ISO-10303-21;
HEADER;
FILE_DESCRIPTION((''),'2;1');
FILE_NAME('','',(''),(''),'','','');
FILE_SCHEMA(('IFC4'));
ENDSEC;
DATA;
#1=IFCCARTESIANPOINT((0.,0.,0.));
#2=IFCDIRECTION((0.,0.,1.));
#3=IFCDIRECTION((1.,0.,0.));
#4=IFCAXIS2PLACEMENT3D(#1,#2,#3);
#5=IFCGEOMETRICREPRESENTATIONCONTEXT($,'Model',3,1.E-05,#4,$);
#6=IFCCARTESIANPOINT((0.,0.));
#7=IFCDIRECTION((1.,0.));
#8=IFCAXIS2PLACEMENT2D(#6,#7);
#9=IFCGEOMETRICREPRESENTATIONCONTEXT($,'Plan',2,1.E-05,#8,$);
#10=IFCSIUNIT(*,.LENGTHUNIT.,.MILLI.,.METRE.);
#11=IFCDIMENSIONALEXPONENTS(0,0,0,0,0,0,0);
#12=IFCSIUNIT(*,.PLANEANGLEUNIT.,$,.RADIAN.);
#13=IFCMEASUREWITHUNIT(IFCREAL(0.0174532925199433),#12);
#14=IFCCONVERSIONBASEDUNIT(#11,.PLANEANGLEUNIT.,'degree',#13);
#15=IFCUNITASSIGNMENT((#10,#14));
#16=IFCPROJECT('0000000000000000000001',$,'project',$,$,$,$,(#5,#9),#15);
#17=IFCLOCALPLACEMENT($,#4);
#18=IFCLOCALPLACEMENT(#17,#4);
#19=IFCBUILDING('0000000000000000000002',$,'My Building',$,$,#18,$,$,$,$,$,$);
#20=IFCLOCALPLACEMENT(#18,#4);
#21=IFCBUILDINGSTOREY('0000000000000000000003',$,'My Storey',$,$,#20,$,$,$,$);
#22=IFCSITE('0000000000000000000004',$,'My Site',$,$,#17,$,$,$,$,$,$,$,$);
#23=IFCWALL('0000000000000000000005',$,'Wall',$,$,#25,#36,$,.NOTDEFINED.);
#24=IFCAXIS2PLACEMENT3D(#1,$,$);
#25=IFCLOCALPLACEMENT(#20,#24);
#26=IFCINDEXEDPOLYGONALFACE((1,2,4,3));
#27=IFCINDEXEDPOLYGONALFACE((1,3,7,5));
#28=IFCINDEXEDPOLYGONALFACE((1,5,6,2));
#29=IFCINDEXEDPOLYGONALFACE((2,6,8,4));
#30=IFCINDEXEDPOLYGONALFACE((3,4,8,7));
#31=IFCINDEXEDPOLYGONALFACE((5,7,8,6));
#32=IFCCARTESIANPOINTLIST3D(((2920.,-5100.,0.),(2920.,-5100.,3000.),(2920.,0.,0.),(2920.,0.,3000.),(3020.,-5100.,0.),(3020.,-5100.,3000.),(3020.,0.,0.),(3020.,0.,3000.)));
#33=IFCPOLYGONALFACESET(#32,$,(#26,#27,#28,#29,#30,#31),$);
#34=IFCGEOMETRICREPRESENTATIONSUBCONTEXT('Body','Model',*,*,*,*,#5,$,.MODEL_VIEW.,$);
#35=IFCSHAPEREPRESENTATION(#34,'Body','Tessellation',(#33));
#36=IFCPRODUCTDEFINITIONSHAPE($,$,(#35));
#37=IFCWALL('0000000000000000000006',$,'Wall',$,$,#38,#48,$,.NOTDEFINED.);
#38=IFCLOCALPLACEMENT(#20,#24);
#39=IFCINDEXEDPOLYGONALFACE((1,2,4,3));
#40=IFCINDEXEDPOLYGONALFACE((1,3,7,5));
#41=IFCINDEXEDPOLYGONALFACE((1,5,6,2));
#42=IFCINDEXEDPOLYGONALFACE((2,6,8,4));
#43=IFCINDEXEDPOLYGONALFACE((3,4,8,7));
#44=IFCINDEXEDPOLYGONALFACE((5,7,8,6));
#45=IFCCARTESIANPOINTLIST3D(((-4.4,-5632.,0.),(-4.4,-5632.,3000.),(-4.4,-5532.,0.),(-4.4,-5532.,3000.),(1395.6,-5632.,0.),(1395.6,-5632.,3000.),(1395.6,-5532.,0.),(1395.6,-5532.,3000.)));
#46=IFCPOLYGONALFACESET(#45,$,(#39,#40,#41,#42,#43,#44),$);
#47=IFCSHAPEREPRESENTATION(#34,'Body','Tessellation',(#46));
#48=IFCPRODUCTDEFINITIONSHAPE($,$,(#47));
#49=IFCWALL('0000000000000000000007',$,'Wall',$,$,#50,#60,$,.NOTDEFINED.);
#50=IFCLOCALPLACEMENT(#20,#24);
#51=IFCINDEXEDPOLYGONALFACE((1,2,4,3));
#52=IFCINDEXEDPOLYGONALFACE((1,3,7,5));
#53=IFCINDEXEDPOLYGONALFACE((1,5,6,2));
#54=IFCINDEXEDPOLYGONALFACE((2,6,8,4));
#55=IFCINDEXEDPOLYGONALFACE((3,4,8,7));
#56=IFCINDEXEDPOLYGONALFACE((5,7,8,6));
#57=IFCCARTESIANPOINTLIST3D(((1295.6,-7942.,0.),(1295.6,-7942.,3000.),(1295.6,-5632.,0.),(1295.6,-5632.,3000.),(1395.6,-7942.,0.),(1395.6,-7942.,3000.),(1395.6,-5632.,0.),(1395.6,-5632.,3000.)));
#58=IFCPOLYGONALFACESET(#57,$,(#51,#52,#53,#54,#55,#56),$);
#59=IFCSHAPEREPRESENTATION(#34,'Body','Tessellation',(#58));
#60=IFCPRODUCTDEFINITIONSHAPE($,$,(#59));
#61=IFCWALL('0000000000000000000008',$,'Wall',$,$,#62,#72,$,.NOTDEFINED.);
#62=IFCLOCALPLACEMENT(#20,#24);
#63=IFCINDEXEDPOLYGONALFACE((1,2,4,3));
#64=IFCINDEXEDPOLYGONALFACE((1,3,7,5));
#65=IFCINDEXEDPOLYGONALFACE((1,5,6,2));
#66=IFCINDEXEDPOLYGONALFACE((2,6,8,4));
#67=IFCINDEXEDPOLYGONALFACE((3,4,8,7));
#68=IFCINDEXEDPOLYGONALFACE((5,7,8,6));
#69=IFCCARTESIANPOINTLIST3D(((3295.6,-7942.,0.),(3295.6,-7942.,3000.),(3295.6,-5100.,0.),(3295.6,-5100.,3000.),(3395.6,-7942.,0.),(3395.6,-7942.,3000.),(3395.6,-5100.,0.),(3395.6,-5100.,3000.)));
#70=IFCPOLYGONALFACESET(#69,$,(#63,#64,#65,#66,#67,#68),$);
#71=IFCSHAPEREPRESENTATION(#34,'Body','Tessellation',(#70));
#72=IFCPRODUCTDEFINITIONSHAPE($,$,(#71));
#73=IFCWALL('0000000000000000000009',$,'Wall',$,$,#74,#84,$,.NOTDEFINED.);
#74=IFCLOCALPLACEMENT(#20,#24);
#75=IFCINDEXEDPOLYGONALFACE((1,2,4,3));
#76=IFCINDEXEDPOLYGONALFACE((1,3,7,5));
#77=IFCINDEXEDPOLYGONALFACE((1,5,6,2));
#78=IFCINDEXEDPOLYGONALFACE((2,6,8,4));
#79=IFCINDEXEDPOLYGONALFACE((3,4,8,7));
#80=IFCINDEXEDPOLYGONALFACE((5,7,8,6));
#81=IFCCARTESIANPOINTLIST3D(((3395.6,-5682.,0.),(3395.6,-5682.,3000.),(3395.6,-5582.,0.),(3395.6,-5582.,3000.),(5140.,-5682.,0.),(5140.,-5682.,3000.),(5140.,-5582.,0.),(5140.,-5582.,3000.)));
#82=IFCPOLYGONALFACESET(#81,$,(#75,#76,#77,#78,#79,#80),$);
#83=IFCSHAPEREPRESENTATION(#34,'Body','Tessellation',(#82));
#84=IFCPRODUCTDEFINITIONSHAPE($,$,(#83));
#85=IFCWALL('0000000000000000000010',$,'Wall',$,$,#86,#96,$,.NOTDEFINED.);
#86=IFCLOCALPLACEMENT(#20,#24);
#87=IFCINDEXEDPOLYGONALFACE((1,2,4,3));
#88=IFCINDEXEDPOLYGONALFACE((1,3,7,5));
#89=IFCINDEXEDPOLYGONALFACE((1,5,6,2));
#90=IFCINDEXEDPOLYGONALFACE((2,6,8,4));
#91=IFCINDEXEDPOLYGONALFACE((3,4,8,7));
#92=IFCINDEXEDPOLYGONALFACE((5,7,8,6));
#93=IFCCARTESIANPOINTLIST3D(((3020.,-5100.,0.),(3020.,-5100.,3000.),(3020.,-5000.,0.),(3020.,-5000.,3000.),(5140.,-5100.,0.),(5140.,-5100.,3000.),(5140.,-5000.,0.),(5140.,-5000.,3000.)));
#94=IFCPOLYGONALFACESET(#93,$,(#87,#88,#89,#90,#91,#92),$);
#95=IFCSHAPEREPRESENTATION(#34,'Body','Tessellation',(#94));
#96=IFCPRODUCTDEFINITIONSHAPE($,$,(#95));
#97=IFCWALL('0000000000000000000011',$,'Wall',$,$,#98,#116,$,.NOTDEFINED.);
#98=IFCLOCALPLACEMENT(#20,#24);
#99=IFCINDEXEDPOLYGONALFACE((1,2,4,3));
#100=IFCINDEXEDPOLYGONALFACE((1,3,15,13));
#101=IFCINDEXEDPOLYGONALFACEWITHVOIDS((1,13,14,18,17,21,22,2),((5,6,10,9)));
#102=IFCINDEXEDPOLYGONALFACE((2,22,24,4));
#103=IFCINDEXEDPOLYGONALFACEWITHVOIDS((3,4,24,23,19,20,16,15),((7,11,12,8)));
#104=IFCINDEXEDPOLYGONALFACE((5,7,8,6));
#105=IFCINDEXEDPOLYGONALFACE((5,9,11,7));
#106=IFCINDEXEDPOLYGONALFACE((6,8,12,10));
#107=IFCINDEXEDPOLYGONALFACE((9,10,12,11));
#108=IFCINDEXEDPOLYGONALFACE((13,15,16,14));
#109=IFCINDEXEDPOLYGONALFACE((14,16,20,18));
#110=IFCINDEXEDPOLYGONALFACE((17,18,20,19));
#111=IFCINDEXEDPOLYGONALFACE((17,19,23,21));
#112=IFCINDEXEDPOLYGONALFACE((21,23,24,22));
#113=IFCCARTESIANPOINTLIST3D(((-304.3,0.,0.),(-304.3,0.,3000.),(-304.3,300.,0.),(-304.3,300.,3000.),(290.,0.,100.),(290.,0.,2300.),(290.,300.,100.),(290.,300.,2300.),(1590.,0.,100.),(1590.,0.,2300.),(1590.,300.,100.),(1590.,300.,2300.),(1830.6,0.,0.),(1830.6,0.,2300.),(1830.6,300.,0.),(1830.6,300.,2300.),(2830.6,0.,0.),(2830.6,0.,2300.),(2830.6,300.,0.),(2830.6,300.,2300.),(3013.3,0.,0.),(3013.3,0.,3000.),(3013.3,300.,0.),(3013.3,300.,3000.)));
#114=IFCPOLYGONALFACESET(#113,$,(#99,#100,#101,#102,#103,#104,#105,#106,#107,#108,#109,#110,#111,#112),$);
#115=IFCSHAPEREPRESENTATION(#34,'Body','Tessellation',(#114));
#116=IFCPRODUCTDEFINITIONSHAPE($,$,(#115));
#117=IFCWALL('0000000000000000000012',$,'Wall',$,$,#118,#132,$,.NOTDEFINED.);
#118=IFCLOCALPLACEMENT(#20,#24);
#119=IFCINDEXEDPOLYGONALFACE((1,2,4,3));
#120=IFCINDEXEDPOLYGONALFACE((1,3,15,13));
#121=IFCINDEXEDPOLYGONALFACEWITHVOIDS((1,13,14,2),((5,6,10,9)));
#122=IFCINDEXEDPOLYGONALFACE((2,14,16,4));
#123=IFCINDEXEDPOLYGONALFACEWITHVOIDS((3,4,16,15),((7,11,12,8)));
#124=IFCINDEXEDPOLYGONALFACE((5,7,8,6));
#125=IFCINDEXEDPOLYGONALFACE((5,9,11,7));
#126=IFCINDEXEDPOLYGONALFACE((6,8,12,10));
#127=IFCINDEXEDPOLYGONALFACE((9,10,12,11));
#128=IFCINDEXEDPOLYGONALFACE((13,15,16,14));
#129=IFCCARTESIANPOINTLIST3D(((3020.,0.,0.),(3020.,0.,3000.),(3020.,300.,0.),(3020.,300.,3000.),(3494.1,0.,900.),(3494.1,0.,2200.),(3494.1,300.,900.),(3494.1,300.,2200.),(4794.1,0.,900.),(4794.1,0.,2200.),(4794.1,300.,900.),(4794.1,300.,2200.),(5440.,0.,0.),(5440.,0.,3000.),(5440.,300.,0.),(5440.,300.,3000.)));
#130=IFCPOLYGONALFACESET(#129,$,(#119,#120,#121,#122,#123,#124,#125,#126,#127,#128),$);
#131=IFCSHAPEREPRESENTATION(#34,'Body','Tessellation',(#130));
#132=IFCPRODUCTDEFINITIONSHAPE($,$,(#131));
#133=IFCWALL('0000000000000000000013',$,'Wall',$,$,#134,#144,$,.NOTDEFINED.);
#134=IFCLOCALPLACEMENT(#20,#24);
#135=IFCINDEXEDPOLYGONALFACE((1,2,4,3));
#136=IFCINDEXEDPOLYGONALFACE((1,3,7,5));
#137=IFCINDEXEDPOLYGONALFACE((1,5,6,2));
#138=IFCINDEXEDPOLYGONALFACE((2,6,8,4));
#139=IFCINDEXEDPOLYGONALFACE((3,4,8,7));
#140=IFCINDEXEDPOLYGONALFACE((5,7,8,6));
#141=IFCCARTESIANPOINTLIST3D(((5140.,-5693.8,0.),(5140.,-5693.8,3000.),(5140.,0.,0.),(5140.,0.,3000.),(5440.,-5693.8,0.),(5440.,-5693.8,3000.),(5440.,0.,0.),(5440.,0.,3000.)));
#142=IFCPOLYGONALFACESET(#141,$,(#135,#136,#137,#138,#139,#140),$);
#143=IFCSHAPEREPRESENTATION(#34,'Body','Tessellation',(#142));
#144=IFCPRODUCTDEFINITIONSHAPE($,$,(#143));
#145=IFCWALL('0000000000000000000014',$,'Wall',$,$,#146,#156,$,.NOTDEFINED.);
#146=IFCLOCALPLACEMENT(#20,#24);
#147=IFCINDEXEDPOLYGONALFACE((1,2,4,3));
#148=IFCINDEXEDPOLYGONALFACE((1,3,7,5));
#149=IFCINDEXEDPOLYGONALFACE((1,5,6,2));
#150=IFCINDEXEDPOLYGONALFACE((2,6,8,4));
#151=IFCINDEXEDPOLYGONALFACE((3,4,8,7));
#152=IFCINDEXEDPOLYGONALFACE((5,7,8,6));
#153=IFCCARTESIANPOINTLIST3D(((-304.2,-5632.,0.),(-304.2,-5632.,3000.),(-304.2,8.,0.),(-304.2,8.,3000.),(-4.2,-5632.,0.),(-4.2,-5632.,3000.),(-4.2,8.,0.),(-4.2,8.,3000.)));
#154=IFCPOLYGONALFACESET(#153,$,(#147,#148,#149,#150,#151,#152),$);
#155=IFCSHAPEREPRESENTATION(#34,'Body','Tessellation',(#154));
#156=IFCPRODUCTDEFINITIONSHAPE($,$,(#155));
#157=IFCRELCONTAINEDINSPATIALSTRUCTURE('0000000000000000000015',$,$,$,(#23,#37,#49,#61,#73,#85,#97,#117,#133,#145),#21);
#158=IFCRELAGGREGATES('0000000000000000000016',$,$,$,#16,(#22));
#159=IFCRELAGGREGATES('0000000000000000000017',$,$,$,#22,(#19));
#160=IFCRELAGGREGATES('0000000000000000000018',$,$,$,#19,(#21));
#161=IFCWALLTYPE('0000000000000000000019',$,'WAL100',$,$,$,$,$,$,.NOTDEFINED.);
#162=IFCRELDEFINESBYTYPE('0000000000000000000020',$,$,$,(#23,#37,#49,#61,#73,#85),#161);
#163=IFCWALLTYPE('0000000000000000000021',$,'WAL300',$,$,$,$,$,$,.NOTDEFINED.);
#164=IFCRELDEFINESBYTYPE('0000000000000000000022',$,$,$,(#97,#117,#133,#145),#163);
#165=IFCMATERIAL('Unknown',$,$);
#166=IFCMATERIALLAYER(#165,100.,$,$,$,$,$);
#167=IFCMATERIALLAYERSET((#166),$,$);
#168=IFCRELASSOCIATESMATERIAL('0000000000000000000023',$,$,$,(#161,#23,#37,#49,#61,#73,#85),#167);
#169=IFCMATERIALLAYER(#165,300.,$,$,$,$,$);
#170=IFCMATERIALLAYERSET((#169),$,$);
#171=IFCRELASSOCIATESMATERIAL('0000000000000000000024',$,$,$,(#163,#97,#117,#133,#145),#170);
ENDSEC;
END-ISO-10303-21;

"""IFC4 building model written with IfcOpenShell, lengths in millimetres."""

from ifc_helpers import new_model, entity, si_unit, converted_unit, frame, origin_with_axes, origin_2d_with_axis, place, context, subcontext, project, spatial, line, indexed_curve, outline, extrude, source, transform, mapped, material, layer, layer_set, layer_usage, type_object, element, save


model = new_model("IFC4")

# Units and contexts
model_context = context("Model", 3, precision=1e-05, world=origin_with_axes())
plan_context = context("Plan", 2, precision=1e-05, world=origin_2d_with_axis())
body_context = subcontext(model_context, "Body", "Model", "MODEL_VIEW")
ifc_project = project(units=[si_unit("LENGTHUNIT", "METRE", prefix="MILLI"), converted_unit("PLANEANGLEUNIT", "degree", entity("IfcReal", 0.0174532925199433), si_unit("PLANEANGLEUNIT", "RADIAN"), dimensions=[0, 0, 0, 0, 0, 0, 0])], contexts=[model_context, plan_context])

# Site, building, storey
site_placement = place(None, origin_with_axes())
site = spatial("IfcSite", under=ifc_project, at=site_placement, Name="My Site")
building_placement = place(site_placement, origin_with_axes())
building = spatial("IfcBuilding", under=site, at=building_placement, Name="My Building")
storey_placement = place(building_placement, origin_with_axes())
storey = spatial("IfcBuildingStorey", under=building, at=storey_placement, Name="My Storey")

# Walls
ifc_material = material(Name="Unknown")
ifc_layer_1 = layer(ifc_material, 100.0)
ifc_layer_set_1 = layer_set([ifc_layer_1])
ifc_layer_usage_1 = layer_usage(ifc_layer_set_1, "AXIS2", "POSITIVE", 0.0)
wall_type_1 = type_object("IfcWallType", Name="WAL100", PredefinedType="NOTDEFINED", material=ifc_layer_set_1)
wall_1_placement = place(storey_placement, frame((2920.0, 0.0, 0.0), z_axis=(0.0, 0.0, 1.0), x_axis=(0.0, -1.0, 0.0)))
element("IfcWall", 1, at=wall_1_placement, inside=storey, type_object=wall_type_1, material=ifc_layer_usage_1, Name="Wall", PredefinedType="NOTDEFINED", context=body_context, shape_type="SweptSolid", body=[
    extrude(outline(indexed_curve([(0.0, 0.0), (0.0, 100.0), (5100.0, 100.0), (5100.0, 0.0), (0.0, 0.0)], self_intersect=False)), origin_with_axes(), (0.0, 0.0, 1.0), 3000.0),
])
ifc_layer_usage_2 = layer_usage(ifc_layer_set_1, "AXIS2", "POSITIVE", 0.0)
wall_2_placement = place(storey_placement, frame((1395.6, -5532.0, 0.0), z_axis=(0.0, 0.0, 1.0), x_axis=(-1.0, 0.000001, 0.0)))
element("IfcWall", 2, at=wall_2_placement, inside=storey, type_object=wall_type_1, material=ifc_layer_usage_2, Name="Wall", PredefinedType="NOTDEFINED", context=body_context, shape_type="SweptSolid", body=[
    extrude(outline(indexed_curve([(0.0, 0.0), (0.0, 100.0), (1400.0, 100.0), (1400.0, 0.0), (0.0, 0.0)], self_intersect=False)), origin_with_axes(), (0.0, 0.0, 1.0), 3000.0),
])
ifc_layer_usage_3 = layer_usage(ifc_layer_set_1, "AXIS2", "POSITIVE", 0.0)
wall_3_placement = place(storey_placement, frame((1295.6, -5632.0, 0.0), z_axis=(0.0, 0.0, 1.0), x_axis=(-0.000001, -1.0, 0.0)))
element("IfcWall", 3, at=wall_3_placement, inside=storey, type_object=wall_type_1, material=ifc_layer_usage_3, Name="Wall", PredefinedType="NOTDEFINED", context=body_context, shape_type="SweptSolid", body=[
    extrude(outline(indexed_curve([(0.0, 0.0), (0.0, 100.0), (2310.0, 100.0), (2310.0, 0.0), (0.0, 0.0)], self_intersect=False)), origin_with_axes(), (0.0, 0.0, 1.0), 3000.0),
])
ifc_layer_usage_4 = layer_usage(ifc_layer_set_1, "AXIS2", "POSITIVE", 0.0)
wall_4_placement = place(storey_placement, frame((3295.6, -5100.0, 0.0), z_axis=(0.0, 0.0, 1.0), x_axis=(-0.000001, -1.0, 0.0)))
element("IfcWall", 4, at=wall_4_placement, inside=storey, type_object=wall_type_1, material=ifc_layer_usage_4, Name="Wall", PredefinedType="NOTDEFINED", context=body_context, shape_type="SweptSolid", body=[
    extrude(outline(indexed_curve([(0.0, 0.0), (0.0, 100.0), (2842.0, 100.0), (2842.0, 0.0), (0.0, 0.0)], self_intersect=False)), origin_with_axes(), (0.0, 0.0, 1.0), 3000.0),
])
ifc_layer_usage_5 = layer_usage(ifc_layer_set_1, "AXIS2", "POSITIVE", 0.0)
wall_5_placement = place(storey_placement, frame((3395.6, -5682.0, 0.0), z_axis=(0.0, 0.0, 1.0), x_axis=(1.0, -0.000001, 0.0)))
element("IfcWall", 5, at=wall_5_placement, inside=storey, type_object=wall_type_1, material=ifc_layer_usage_5, Name="Wall", PredefinedType="NOTDEFINED", context=body_context, shape_type="SweptSolid", body=[
    extrude(outline(indexed_curve([(0.0, 0.0), (0.0, 100.0), (1744.4, 100.0), (1744.4, 0.0), (0.0, 0.0)], self_intersect=False)), origin_with_axes(), (0.0, 0.0, 1.0), 3000.0),
])
ifc_layer_usage_6 = layer_usage(ifc_layer_set_1, "AXIS2", "POSITIVE", 0.0)
wall_6_placement = place(storey_placement, frame((3020.0, -5100.0, 0.0), z_axis=(0.0, 0.0, 1.0), x_axis=(1.0, 0.0, 0.0)))
element("IfcWall", 6, at=wall_6_placement, inside=storey, type_object=wall_type_1, material=ifc_layer_usage_6, Name="Wall", PredefinedType="NOTDEFINED", context=body_context, shape_type="SweptSolid", body=[
    extrude(outline(indexed_curve([(0.0, 0.0), (0.0, 100.0), (2120.0, 100.0), (2120.0, 0.0), (0.0, 0.0)], self_intersect=False)), origin_with_axes(), (0.0, 0.0, 1.0), 3000.0),
])

# Wall, openings
ifc_layer_2 = layer(ifc_material, 300.0)
ifc_layer_set_2 = layer_set([ifc_layer_2])
ifc_layer_usage_7 = layer_usage(ifc_layer_set_2, "AXIS2", "POSITIVE", 0.0)
wall_type_2 = type_object("IfcWallType", Name="WAL300", PredefinedType="NOTDEFINED", material=ifc_layer_set_2)
wall_7_placement = place(storey_placement, frame((-304.3, 0.0, 0.0), z_axis=(0.0, 0.0, 1.0), x_axis=(1.0, 0.0, 0.0)))
wall_7 = element("IfcWall", 7, at=wall_7_placement, inside=storey, type_object=wall_type_2, material=ifc_layer_usage_7, Name="Wall", PredefinedType="NOTDEFINED", context=body_context, shape_type="SweptSolid", body=[
    extrude(outline(indexed_curve([(0.0, 0.0), (0.0, 300.0), (3317.5, 300.0), (3317.5, 0.0), (0.0, 0.0)], self_intersect=False)), origin_with_axes(), (0.0, 0.0, 1.0), 3000.0),
])
shared_shape_1 = source(origin_with_axes(), body_context, "Body", "SweptSolid", [
    extrude(outline(indexed_curve([(0.0, 0.0, 0.0), (1300.0, 0.0, 0.0), (1300.0, 0.0, 2200.0), (0.0, 0.0, 2200.0)], segments=[line(1, 2), line(2, 3), line(3, 4), line(4, 1)])), frame((0.0, -100.0, 0.0), z_axis=(0.0, 0.0, 1.0), x_axis=(1.0, 0.0, 0.0)), (0.0, 1.0, 0.0), 500.0),
])
opening_1_placement = place(wall_7_placement, frame((594.3, 50.0, 100.0), z_axis=(0.0, 0.0, 1.0), x_axis=(1.0, 0.0, 0.0)))
element("IfcOpeningElement", 8, at=opening_1_placement, cuts=wall_7, PredefinedType="OPENING", context=body_context, shape_type="MappedRepresentation", body=[
    mapped(shared_shape_1, transform((0.0, 0.0, 0.0), x_axis=(1.0, 0.0, 0.0), y_axis=(0.0, 1.0, 0.0), z_axis=(0.0, 0.0, 1.0), scale=1.0)),
])
shared_shape_2 = source(origin_with_axes(), body_context, "Body", "SweptSolid", [
    extrude(outline(indexed_curve([(0.0, 0.0, 0.0), (1000.0, 0.0, 0.0), (1000.0, 0.0, 2300.0), (0.0, 0.0, 2300.0)], segments=[line(1, 2), line(2, 3), line(3, 4), line(4, 1)])), frame((0.0, -100.0, 0.0), z_axis=(0.0, 0.0, 1.0), x_axis=(1.0, 0.0, 0.0)), (0.0, 1.0, 0.0), 500.0),
])
opening_2_placement = place(wall_7_placement, frame((2134.9, 0.0, 0.0), z_axis=(0.0, 0.0, 1.0), x_axis=(1.0, 0.0, 0.0)))
element("IfcOpeningElement", 9, at=opening_2_placement, cuts=wall_7, PredefinedType="OPENING", context=body_context, shape_type="MappedRepresentation", body=[
    mapped(shared_shape_2, transform((0.0, 0.0, 0.0), x_axis=(1.0, 0.0, 0.0), y_axis=(0.0, 1.0, 0.0), z_axis=(0.0, 0.0, 1.0), scale=1.0)),
])

# Wall, opening
ifc_layer_usage_8 = layer_usage(ifc_layer_set_2, "AXIS2", "POSITIVE", 0.0)
wall_8_placement = place(storey_placement, frame((3020.0, 0.0, 0.0), z_axis=(0.0, 0.0, 1.0), x_axis=(1.0, 0.0, 0.0)))
wall_8 = element("IfcWall", 10, at=wall_8_placement, inside=storey, type_object=wall_type_2, material=ifc_layer_usage_8, Name="Wall", PredefinedType="NOTDEFINED", context=body_context, shape_type="SweptSolid", body=[
    extrude(outline(indexed_curve([(0.0, 0.0), (0.0, 300.0), (2420.0, 300.0), (2420.0, 0.0), (0.0, 0.0)], self_intersect=False)), origin_with_axes(), (0.0, 0.0, 1.0), 3000.0),
])
shared_shape_3 = source(origin_with_axes(), body_context, "Body", "SweptSolid", [
    extrude(outline(indexed_curve([(0.0, 0.0, 0.0), (1300.0, 0.0, 0.0), (1300.0, 0.0, 1300.0), (0.0, 0.0, 1300.0)], segments=[line(1, 2), line(2, 3), line(3, 4), line(4, 1)])), frame((0.0, -100.0, 0.0), z_axis=(0.0, 0.0, 1.0), x_axis=(1.0, 0.0, 0.0)), (0.0, 1.0, 0.0), 500.0),
])
opening_3_placement = place(wall_8_placement, frame((474.1, 0.0, 900.0), z_axis=(0.0, 0.0, 1.0), x_axis=(1.0, 0.0, 0.0)))
element("IfcOpeningElement", 11, at=opening_3_placement, cuts=wall_8, PredefinedType="OPENING", context=body_context, shape_type="MappedRepresentation", body=[
    mapped(shared_shape_3, transform((0.0, 0.0, 0.0), x_axis=(1.0, 0.0, 0.0), y_axis=(0.0, 1.0, 0.0), z_axis=(0.0, 0.0, 1.0), scale=1.0)),
])

# Walls
ifc_layer_usage_9 = layer_usage(ifc_layer_set_2, "AXIS2", "POSITIVE", 0.0)
wall_9_placement = place(storey_placement, frame((5140.0, 0.0, 0.0), z_axis=(0.0, 0.0, 1.0), x_axis=(0.0, -1.0, 0.0)))
element("IfcWall", 12, at=wall_9_placement, inside=storey, type_object=wall_type_2, material=ifc_layer_usage_9, Name="Wall", PredefinedType="NOTDEFINED", context=body_context, shape_type="SweptSolid", body=[
    extrude(outline(indexed_curve([(0.0, 0.0), (0.0, 300.0), (5693.8, 300.0), (5693.8, 0.0), (0.0, 0.0)], self_intersect=False)), origin_with_axes(), (0.0, 0.0, 1.0), 3000.0),
])
ifc_layer_usage_10 = layer_usage(ifc_layer_set_2, "AXIS2", "POSITIVE", 0.0)
wall_10_placement = place(storey_placement, frame((-4.2, -5632.0, 0.0), z_axis=(0.0, 0.0, 1.0), x_axis=(0.0, 1.0, 0.0)))
element("IfcWall", 13, at=wall_10_placement, inside=storey, type_object=wall_type_2, material=ifc_layer_usage_10, Name="Wall", PredefinedType="NOTDEFINED", context=body_context, shape_type="SweptSolid", body=[
    extrude(outline(indexed_curve([(0.0, 0.0), (0.0, 300.0), (5640.0, 300.0), (5640.0, 0.0), (0.0, 0.0)], self_intersect=False)), origin_with_axes(), (0.0, 0.0, 1.0), 3000.0),
])

save(model, "model.ifc")
